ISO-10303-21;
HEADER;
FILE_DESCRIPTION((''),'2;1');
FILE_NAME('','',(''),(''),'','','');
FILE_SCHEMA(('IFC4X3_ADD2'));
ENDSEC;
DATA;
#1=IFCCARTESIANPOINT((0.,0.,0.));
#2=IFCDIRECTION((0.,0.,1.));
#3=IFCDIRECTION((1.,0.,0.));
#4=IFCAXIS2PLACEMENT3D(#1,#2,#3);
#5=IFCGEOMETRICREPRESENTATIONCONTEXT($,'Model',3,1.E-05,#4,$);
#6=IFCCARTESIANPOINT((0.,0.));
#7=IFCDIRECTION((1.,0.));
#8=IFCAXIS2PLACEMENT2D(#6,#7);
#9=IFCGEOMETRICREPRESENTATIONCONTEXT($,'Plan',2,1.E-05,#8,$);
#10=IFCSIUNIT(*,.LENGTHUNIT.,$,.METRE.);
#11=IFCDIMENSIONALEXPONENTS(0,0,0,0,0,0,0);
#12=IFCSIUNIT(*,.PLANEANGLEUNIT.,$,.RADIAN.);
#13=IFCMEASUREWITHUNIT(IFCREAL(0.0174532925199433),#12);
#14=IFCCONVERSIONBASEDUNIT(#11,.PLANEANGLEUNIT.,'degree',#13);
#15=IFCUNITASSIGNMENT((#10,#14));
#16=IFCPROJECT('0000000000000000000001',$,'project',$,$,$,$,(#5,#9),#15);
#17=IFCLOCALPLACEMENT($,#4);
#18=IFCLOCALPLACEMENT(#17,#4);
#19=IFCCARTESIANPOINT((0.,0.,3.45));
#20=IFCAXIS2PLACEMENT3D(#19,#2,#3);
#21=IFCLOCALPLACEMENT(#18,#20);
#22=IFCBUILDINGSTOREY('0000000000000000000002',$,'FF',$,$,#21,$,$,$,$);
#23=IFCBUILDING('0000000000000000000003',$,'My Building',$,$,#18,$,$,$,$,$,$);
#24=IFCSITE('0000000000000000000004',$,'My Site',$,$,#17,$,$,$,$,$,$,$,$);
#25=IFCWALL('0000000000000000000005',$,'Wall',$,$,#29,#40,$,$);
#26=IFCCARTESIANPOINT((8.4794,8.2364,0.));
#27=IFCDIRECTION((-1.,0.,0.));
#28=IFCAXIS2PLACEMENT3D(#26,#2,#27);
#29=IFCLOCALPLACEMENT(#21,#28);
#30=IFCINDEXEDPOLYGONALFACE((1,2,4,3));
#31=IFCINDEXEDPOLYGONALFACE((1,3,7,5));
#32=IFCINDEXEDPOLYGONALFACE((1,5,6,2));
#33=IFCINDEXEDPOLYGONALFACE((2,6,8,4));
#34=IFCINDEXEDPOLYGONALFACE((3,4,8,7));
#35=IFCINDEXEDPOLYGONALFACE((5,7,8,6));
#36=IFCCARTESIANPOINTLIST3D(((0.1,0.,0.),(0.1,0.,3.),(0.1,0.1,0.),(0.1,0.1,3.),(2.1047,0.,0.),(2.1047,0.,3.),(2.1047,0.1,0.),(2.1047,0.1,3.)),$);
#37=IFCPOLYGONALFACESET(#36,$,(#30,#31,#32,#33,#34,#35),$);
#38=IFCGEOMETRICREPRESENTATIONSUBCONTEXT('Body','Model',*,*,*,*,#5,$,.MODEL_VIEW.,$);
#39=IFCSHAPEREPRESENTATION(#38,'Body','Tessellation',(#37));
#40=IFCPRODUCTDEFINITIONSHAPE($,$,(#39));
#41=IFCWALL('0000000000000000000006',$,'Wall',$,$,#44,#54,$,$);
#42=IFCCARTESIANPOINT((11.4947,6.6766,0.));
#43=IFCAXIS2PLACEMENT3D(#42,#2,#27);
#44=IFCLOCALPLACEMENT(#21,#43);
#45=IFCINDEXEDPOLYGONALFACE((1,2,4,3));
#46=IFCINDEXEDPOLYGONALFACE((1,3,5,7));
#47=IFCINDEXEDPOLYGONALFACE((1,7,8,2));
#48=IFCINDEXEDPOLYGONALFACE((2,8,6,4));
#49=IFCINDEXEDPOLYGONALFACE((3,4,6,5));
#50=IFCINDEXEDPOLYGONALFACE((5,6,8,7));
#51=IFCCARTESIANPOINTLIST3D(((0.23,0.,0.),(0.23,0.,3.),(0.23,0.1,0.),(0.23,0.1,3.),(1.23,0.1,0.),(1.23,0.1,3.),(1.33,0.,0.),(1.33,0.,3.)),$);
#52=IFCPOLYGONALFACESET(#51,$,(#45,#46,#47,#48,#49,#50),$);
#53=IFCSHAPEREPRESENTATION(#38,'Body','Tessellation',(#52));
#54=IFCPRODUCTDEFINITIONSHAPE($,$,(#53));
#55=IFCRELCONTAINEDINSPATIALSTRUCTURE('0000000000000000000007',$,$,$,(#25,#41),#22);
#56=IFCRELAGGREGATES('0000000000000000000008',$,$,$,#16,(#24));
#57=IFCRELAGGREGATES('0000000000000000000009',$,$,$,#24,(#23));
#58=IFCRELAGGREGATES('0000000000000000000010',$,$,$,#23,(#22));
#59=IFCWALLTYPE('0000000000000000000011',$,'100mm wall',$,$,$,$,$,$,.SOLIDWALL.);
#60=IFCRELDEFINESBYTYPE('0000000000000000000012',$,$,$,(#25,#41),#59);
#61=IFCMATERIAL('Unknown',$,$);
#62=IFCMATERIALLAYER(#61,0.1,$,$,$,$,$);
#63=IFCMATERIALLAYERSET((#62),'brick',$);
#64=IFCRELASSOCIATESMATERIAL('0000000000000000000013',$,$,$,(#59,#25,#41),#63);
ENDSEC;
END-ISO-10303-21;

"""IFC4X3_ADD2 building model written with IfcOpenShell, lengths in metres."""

from ifc_helpers import new_model, entity, si_unit, converted_unit, frame, origin_with_axes, origin_2d_with_axis, place, context, subcontext, project, spatial, line, indexed_curve, outline, extrude, material, layer, layer_set, layer_usage, type_object, element, save


model = new_model("IFC4X3_ADD2")

# Units and contexts
model_context = context("Model", 3, precision=1e-05, world=origin_with_axes())
plan_context = context("Plan", 2, precision=1e-05, world=origin_2d_with_axis())
body_context_1 = subcontext(model_context, "Body", "Model", "MODEL_VIEW")
ifc_project = project(units=[si_unit("LENGTHUNIT", "METRE"), converted_unit("PLANEANGLEUNIT", "degree", entity("IfcReal", 0.0174532925199433), si_unit("PLANEANGLEUNIT", "RADIAN"), dimensions=[0, 0, 0, 0, 0, 0, 0])], contexts=[model_context, plan_context])

# Site, building, storey
site_placement = place(None, origin_with_axes())
site = spatial("IfcSite", under=ifc_project, at=site_placement, Name="My Site")
building_placement = place(site_placement, origin_with_axes())
building = spatial("IfcBuilding", under=site, at=building_placement, Name="My Building")
storey_placement = place(building_placement, frame((0.0, 0.0, 3.45), z_axis=(0.0, 0.0, 1.0), x_axis=(1.0, 0.0, 0.0)))
storey = spatial("IfcBuildingStorey", under=building, at=storey_placement, Name="FF")

# Shared definitions
ifc_material = material(Name="Unknown")

# Shared definitions
ifc_layer_1 = layer(ifc_material, 0.1)
ifc_layer_set_1 = layer_set([ifc_layer_1], Name="brick")
wall_type_1 = type_object("IfcWallType", Name="100mm wall", PredefinedType="SOLIDWALL", material=ifc_layer_set_1)

# Wall
ifc_layer_usage_1 = layer_usage(ifc_layer_set_1, "AXIS2", "POSITIVE", 0.0)
wall_1_placement = place(storey_placement, frame((8.4794, 8.2364, 0.0), z_axis=(0.0, 0.0, 1.0), x_axis=(-1.0, 0.0, 0.0)))
element("IfcWall", 1, at=wall_1_placement, inside=storey, type_object=wall_type_1, material=ifc_layer_usage_1, Name="Wall", context=body_context_1, shape_type="SweptSolid", body=[
    extrude(outline(indexed_curve([(0.1, 0.0), (0.1, 0.1), (2.1047, 0.1), (2.1047, 0.0)], segments=[line(1, 2, 3, 4, 1)])), origin_with_axes(), (0.0, 0.0, 1.0), 3.0),
])

# Wall
ifc_layer_usage_2 = layer_usage(ifc_layer_set_1, "AXIS2", "POSITIVE", 0.0)
wall_2_placement = place(storey_placement, frame((11.4947, 6.6766, 0.0), z_axis=(0.0, 0.0, 1.0), x_axis=(-1.0, 0.0, 0.0)))
element("IfcWall", 2, at=wall_2_placement, inside=storey, type_object=wall_type_1, material=ifc_layer_usage_2, Name="Wall", context=body_context_1, shape_type="SweptSolid", body=[
    extrude(outline(indexed_curve([(0.23, 0.0), (0.23, 0.1), (1.23, 0.1), (1.33, 0.0)], segments=[line(1, 2, 3, 4, 1)])), origin_with_axes(), (0.0, 0.0, 1.0), 3.0),
])

save(model, "model.ifc")
